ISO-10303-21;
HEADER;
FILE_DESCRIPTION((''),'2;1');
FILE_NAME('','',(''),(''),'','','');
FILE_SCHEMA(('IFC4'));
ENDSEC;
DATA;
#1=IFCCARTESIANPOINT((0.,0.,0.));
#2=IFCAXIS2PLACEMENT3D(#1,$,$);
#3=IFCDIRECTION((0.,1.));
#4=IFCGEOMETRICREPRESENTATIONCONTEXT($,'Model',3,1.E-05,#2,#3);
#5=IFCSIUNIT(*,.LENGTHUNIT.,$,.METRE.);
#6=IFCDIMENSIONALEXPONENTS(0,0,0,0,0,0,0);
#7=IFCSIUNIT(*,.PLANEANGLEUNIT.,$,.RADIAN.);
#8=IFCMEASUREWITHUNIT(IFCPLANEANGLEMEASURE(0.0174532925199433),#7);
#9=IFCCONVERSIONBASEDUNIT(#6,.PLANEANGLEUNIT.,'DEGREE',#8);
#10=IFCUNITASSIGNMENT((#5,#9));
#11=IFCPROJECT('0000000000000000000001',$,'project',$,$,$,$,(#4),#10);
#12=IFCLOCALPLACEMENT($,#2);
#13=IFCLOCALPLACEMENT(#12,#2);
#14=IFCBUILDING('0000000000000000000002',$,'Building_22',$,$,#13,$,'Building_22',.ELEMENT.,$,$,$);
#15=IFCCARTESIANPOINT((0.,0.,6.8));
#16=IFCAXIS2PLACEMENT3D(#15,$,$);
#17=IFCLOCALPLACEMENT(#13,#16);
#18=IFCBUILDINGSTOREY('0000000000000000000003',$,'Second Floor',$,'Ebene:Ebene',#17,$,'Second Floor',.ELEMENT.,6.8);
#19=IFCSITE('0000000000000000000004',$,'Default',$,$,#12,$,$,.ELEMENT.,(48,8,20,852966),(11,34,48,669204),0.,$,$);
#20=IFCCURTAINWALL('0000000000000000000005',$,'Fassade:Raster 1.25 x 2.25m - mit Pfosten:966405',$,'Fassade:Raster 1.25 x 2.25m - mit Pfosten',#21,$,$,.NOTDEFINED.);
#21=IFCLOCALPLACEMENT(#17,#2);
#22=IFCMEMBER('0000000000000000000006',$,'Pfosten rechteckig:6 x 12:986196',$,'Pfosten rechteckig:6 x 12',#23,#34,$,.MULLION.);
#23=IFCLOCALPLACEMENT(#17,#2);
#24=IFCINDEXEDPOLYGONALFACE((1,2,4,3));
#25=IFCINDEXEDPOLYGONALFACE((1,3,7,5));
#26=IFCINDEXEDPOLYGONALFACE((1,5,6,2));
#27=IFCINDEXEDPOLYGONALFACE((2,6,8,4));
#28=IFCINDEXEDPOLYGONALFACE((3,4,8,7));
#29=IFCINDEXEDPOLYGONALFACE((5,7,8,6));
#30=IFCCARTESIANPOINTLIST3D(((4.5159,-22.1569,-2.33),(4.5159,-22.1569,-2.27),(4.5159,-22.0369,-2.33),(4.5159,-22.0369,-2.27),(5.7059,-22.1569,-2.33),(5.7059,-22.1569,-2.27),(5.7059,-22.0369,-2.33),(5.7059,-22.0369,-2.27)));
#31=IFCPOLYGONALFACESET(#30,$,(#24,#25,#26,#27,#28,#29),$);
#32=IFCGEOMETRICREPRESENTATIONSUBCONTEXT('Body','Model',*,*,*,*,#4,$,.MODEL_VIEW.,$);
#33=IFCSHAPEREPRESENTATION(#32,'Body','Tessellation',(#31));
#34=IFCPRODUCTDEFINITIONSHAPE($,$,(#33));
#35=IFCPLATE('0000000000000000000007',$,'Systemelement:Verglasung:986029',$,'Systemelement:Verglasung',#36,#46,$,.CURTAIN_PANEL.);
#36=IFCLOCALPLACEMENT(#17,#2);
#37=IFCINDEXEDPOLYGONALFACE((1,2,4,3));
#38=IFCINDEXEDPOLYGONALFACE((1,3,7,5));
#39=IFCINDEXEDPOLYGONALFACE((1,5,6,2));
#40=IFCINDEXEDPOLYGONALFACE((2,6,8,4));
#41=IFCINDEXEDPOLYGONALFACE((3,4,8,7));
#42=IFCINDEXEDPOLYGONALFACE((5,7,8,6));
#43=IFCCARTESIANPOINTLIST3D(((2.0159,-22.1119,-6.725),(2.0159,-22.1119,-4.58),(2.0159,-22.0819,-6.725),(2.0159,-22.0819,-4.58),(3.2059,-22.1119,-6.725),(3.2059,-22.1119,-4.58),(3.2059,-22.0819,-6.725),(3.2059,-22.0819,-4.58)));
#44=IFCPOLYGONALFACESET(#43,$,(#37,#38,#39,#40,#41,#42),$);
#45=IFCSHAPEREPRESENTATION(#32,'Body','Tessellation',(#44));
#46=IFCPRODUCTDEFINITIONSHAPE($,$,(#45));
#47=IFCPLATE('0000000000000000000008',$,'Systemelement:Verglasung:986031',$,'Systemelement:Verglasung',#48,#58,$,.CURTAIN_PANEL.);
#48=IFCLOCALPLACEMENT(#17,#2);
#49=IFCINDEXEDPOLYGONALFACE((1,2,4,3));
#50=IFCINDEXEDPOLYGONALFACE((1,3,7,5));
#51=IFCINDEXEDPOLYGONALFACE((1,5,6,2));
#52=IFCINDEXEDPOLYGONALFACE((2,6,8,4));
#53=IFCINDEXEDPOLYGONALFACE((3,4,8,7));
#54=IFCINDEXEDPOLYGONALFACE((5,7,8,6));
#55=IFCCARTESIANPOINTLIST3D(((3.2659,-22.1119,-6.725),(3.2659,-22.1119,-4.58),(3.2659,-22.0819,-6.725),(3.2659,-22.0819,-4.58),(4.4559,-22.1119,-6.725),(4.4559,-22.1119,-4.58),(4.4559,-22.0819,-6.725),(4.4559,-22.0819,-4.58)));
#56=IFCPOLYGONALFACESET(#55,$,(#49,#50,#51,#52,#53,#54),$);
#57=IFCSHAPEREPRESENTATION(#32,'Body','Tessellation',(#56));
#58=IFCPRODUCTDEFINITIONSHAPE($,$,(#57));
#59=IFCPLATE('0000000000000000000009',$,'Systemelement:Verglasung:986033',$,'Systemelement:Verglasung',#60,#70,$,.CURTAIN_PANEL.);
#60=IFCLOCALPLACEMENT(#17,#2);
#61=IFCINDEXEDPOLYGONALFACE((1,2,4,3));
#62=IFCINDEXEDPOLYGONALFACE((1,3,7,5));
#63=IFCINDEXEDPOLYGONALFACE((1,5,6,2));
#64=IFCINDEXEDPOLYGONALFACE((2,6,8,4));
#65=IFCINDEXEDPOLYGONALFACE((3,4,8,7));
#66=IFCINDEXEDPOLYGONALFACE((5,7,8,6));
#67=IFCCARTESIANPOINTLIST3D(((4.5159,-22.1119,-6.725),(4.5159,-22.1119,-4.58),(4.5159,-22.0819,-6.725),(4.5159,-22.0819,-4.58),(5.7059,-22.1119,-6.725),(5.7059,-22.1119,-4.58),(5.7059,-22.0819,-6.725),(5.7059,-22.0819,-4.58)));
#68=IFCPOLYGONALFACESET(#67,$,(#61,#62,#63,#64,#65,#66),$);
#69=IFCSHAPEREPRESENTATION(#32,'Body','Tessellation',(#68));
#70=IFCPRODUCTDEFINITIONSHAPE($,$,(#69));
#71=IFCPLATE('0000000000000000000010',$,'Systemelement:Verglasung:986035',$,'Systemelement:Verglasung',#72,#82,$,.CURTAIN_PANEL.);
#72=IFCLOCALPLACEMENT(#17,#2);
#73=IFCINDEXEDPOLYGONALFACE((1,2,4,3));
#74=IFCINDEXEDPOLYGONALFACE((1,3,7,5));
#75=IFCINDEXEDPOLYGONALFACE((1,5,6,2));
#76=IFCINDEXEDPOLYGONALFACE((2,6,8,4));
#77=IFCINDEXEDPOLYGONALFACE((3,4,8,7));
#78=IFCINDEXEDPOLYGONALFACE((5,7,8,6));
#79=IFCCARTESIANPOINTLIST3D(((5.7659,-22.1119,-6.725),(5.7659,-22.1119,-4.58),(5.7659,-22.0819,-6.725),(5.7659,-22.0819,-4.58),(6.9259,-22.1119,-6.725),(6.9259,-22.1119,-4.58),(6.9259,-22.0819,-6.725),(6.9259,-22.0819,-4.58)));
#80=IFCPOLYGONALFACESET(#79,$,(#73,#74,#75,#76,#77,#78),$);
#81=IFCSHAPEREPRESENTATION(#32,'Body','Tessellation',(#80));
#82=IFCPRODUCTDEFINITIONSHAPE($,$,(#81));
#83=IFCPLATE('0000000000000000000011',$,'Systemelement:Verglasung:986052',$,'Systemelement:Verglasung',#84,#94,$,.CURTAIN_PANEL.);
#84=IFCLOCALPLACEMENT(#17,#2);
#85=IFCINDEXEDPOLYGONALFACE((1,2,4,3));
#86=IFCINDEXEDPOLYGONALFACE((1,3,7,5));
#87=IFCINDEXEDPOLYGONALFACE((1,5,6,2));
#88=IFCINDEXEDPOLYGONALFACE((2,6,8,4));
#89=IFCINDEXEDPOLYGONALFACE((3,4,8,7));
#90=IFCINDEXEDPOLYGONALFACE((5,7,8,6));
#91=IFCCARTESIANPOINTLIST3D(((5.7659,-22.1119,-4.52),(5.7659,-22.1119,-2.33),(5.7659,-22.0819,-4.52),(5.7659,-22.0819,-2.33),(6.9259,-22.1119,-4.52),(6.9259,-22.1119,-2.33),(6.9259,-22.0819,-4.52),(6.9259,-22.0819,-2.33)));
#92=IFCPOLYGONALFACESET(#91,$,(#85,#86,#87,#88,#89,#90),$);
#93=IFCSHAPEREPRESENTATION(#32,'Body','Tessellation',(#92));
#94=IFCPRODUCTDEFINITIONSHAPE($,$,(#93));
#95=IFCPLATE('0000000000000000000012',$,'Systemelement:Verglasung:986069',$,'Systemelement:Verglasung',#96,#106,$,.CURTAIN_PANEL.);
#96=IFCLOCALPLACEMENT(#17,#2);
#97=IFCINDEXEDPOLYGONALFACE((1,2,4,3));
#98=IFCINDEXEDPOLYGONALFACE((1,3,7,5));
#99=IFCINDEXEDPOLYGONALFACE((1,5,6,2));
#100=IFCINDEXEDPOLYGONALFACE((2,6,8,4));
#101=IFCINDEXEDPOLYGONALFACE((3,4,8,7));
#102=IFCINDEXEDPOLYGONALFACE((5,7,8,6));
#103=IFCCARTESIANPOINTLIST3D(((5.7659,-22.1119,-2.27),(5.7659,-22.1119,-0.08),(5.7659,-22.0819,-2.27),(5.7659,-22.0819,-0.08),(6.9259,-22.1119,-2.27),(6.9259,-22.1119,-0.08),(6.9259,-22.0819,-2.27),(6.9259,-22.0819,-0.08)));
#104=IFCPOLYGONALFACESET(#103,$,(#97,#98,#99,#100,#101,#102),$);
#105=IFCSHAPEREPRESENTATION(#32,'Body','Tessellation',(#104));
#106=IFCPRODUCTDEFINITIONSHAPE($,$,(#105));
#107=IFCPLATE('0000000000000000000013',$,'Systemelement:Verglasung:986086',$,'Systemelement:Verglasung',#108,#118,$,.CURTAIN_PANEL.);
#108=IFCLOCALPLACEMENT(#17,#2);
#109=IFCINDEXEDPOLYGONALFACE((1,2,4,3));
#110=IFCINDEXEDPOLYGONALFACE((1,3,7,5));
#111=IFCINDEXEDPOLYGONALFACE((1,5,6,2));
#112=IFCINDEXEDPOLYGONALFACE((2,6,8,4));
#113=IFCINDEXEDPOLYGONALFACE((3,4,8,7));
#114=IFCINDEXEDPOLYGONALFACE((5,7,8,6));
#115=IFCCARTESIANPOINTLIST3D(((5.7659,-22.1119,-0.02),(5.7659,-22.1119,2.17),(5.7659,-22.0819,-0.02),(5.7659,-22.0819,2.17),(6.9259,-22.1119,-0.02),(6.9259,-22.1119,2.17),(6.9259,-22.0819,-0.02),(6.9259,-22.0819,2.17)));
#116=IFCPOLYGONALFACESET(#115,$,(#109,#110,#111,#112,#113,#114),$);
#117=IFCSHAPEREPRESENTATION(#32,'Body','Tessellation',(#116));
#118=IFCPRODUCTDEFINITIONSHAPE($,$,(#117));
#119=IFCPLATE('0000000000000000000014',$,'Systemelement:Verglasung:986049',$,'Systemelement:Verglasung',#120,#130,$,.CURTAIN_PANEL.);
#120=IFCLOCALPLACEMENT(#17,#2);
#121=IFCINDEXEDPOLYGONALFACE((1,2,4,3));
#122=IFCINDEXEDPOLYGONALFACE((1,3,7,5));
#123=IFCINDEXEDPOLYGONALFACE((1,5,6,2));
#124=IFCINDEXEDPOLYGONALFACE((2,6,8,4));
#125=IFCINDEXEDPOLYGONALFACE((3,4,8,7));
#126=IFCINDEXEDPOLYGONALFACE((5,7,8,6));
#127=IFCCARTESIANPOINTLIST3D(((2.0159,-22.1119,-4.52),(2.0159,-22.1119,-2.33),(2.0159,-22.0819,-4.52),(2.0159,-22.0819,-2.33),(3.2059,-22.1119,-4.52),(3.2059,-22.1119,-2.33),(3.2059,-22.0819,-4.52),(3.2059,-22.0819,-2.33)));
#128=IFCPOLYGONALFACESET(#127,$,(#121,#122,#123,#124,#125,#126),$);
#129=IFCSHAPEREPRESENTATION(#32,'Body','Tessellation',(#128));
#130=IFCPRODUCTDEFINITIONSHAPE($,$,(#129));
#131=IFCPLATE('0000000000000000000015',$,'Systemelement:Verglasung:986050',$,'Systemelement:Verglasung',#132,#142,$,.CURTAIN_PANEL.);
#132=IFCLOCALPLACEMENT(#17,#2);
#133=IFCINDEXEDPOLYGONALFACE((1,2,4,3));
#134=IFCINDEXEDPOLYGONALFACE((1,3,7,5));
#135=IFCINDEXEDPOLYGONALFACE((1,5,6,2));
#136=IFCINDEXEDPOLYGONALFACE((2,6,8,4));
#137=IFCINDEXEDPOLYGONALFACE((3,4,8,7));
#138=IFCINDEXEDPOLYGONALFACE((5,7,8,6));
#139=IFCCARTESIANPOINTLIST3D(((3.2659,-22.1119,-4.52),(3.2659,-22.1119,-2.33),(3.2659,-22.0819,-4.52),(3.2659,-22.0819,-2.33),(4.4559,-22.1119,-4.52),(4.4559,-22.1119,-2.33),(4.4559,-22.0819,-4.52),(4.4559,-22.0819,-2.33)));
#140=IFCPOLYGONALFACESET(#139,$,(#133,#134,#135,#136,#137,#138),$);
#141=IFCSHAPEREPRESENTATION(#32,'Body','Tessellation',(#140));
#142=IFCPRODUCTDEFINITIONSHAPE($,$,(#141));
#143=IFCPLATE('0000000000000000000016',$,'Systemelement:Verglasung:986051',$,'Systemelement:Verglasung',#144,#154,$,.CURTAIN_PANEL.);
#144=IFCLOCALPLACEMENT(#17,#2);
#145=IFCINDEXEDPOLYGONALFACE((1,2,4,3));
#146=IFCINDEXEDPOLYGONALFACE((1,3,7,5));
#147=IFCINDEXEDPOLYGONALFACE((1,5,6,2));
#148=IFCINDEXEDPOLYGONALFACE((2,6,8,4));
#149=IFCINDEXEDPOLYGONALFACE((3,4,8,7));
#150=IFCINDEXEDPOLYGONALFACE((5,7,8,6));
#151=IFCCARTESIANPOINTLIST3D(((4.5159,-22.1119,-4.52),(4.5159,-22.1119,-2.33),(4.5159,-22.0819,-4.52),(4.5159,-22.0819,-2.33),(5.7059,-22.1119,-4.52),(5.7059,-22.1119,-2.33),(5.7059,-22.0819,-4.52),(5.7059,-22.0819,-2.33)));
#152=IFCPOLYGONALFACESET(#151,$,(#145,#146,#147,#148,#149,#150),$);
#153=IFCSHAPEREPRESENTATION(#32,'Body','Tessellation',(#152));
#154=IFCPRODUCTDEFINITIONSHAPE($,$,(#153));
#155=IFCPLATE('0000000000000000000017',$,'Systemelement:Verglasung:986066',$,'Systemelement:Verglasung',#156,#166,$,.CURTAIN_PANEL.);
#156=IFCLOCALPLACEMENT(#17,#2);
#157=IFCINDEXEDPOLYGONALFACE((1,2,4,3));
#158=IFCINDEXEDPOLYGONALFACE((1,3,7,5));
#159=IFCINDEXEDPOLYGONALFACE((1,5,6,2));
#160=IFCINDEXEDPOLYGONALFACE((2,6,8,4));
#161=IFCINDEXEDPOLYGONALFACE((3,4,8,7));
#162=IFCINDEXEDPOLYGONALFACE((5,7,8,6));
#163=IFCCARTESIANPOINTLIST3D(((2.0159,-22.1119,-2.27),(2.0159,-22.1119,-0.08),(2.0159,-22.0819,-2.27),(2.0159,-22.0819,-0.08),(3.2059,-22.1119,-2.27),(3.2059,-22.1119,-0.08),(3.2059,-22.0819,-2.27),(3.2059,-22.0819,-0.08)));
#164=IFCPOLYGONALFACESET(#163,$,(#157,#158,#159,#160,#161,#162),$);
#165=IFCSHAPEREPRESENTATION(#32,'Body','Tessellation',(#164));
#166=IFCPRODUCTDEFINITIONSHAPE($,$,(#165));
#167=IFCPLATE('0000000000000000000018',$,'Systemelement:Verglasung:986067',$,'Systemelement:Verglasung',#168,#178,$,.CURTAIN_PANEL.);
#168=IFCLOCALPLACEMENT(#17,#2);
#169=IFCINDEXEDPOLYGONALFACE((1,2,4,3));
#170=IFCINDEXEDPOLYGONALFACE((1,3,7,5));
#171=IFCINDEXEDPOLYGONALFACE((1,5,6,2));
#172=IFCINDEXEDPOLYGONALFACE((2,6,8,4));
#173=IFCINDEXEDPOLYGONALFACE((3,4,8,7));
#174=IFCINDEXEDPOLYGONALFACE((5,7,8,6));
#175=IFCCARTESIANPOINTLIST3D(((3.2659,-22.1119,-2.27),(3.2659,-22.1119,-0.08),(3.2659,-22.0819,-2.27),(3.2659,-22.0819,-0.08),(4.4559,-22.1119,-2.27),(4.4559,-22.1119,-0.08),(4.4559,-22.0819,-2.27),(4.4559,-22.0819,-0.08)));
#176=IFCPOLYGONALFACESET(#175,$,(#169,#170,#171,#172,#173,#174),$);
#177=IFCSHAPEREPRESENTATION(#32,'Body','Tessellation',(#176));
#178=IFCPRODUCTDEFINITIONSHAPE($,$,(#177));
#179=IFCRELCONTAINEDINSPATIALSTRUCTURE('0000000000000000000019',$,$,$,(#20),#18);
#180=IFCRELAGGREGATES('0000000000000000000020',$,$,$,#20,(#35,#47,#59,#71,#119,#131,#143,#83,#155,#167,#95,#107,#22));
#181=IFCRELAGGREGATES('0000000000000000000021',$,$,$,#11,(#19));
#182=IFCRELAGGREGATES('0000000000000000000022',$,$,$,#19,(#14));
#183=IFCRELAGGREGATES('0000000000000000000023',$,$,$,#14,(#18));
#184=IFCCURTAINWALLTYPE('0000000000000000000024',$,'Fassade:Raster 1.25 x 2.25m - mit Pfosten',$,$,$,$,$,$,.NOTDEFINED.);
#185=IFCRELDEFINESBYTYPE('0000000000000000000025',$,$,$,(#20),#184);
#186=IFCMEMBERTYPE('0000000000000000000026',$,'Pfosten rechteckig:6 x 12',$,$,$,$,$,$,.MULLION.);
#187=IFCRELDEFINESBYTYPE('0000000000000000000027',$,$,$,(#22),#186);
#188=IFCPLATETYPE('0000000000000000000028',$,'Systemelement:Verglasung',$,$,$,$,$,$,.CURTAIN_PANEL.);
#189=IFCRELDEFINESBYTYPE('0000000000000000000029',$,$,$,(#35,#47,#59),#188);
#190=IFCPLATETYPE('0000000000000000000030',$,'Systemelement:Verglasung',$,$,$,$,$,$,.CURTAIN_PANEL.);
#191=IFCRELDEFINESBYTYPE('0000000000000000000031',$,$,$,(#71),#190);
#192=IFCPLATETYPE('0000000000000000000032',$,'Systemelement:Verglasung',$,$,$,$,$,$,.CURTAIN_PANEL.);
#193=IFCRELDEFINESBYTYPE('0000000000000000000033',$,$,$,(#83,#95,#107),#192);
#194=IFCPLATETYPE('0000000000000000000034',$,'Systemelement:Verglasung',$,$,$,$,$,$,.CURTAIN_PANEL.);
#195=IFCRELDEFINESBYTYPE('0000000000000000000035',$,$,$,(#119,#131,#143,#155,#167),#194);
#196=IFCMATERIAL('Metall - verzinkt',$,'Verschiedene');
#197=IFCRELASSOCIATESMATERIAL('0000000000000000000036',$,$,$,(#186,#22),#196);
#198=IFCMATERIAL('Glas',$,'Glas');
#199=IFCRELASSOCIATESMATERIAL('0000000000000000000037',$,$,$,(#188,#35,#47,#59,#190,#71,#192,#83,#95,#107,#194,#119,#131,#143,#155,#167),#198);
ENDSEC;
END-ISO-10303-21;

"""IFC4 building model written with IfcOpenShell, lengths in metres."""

from ifc_helpers import new_model, entity, si_unit, converted_unit, direction, frame, origin, place, context, subcontext, project, spatial, indexed_curve, outline, extrude, source, transform, mapped, material, type_object, type_shapes, element, aggregate, save


model = new_model("IFC4")

# Units and contexts
model_context = context("Model", 3, precision=1e-05, world=origin(), true_north=direction((0.0, 1.0)))
body_context = subcontext(model_context, "Body", "Model", "MODEL_VIEW")
ifc_project = project(units=[si_unit("LENGTHUNIT", "METRE"), converted_unit("PLANEANGLEUNIT", "DEGREE", entity("IfcPlaneAngleMeasure", 0.0174532925199433), si_unit("PLANEANGLEUNIT", "RADIAN"), dimensions=[0, 0, 0, 0, 0, 0, 0])], contexts=[model_context])

# Site, building, storey
site_placement = place(None, origin())
site = spatial("IfcSite", under=ifc_project, at=site_placement, Name="Default", CompositionType="ELEMENT", RefLatitude=(48, 8, 20, 852966), RefLongitude=(11, 34, 48, 669204), RefElevation=0.0)
building_placement = place(site_placement, origin())
building = spatial("IfcBuilding", under=site, at=building_placement, Name="Building_22", LongName="Building_22", CompositionType="ELEMENT")
storey_placement = place(building_placement, frame((0.0, 0.0, 6.8)))
storey = spatial("IfcBuildingStorey", under=building, at=storey_placement, Name="Second Floor", ObjectType="Ebene:Ebene", LongName="Second Floor", CompositionType="ELEMENT", Elevation=6.8)

# Curtain wall, member, plates
curtain_wall_type = type_object("IfcCurtainWallType", Name="Fassade:Raster 1.25 x 2.25m - mit Pfosten", PredefinedType="NOTDEFINED")
curtain_wall_placement = place(storey_placement, frame((0.0, 0.0, -6.8)))
curtain_wall = element("IfcCurtainWall", 1, at=curtain_wall_placement, inside=storey, type_object=curtain_wall_type, Name="Fassade:Raster 1.25 x 2.25m - mit Pfosten:966405", ObjectType="Fassade:Raster 1.25 x 2.25m - mit Pfosten", PredefinedType="NOTDEFINED")
ifc_material_1 = material(Name="Metall - verzinkt", Category="Verschiedene")
member_type_1 = type_object("IfcMemberType", Name="Pfosten rechteckig:6 x 12", PredefinedType="MULLION", material=ifc_material_1)
shared_shape_1 = source(origin(), body_context, "Body", "SweptSolid", [
    extrude(outline(indexed_curve([(-0.03, -0.06), (0.03, -0.06), (0.03, 0.06), (-0.03, 0.06), (-0.03, -0.06)], self_intersect=False)), frame((0.0, 0.0, -1.19), z_axis=(0.0, 0.0, 1.0), x_axis=(-1.0, 0.0, 0.0)), (0.0, 0.0, 1.0), 1.19),
])
type_shapes(member_type_1, [shared_shape_1])
member_1_placement = place(curtain_wall_placement, frame((5.7059, -22.0969, 4.5), z_axis=(1.0, 0.0, 0.0), x_axis=(0.0, 0.0, 1.0)))
member_1 = element("IfcMember", 2, at=member_1_placement, type_object=member_type_1, material=ifc_material_1, Name="Pfosten rechteckig:6 x 12:986196", ObjectType="Pfosten rechteckig:6 x 12", PredefinedType="MULLION", context=body_context, shape_type="MappedRepresentation", body=[
    mapped(shared_shape_1, transform((0.0, 0.0, 0.0), scale=1.0)),
])
ifc_material_2 = material(Name="Glas", Category="Glas")
plate_type_1 = type_object("IfcPlateType", Name="Systemelement:Verglasung", PredefinedType="CURTAIN_PANEL", material=ifc_material_2)
shared_shape_2 = source(origin(), body_context, "Body", "SweptSolid", [
    extrude(outline(indexed_curve([(-0.015, -0.595), (0.015, -0.595), (0.015, 0.595), (-0.015, 0.595), (-0.015, -0.595)], self_intersect=False)), frame((0.0, 0.0, 0.0), z_axis=(0.0, 0.0, 1.0), x_axis=(0.0, 1.0, 0.0)), (0.0, 0.0, 1.0), 2.145),
])
type_shapes(plate_type_1, [shared_shape_2])
plate_1_placement = place(curtain_wall_placement, frame((2.6109, -22.0969, 0.075)))
plate_1 = element("IfcPlate", 3, at=plate_1_placement, type_object=plate_type_1, material=ifc_material_2, Name="Systemelement:Verglasung:986029", ObjectType="Systemelement:Verglasung", PredefinedType="CURTAIN_PANEL", context=body_context, shape_type="MappedRepresentation", body=[
    mapped(shared_shape_2, transform((0.0, 0.0, 0.0), scale=1.0)),
])
plate_2_placement = place(curtain_wall_placement, frame((3.8609, -22.0969, 0.075)))
plate_2 = element("IfcPlate", 4, at=plate_2_placement, type_object=plate_type_1, material=ifc_material_2, Name="Systemelement:Verglasung:986031", ObjectType="Systemelement:Verglasung", PredefinedType="CURTAIN_PANEL", context=body_context, shape_type="MappedRepresentation", body=[
    mapped(shared_shape_2, transform((0.0, 0.0, 0.0), scale=1.0)),
])
plate_3_placement = place(curtain_wall_placement, frame((5.1109, -22.0969, 0.075)))
plate_3 = element("IfcPlate", 5, at=plate_3_placement, type_object=plate_type_1, material=ifc_material_2, Name="Systemelement:Verglasung:986033", ObjectType="Systemelement:Verglasung", PredefinedType="CURTAIN_PANEL", context=body_context, shape_type="MappedRepresentation", body=[
    mapped(shared_shape_2, transform((0.0, 0.0, 0.0), scale=1.0)),
])
plate_type_2 = type_object("IfcPlateType", Name="Systemelement:Verglasung", PredefinedType="CURTAIN_PANEL", material=ifc_material_2)
shared_shape_3 = source(origin(), body_context, "Body", "SweptSolid", [
    extrude(outline(indexed_curve([(-0.015, -0.58), (0.015, -0.58), (0.015, 0.58), (-0.015, 0.58), (-0.015, -0.58)], self_intersect=False)), frame((0.0, 0.0, 0.0), z_axis=(0.0, 0.0, 1.0), x_axis=(0.0, 1.0, 0.0)), (0.0, 0.0, 1.0), 2.145),
])
type_shapes(plate_type_2, [shared_shape_3])
plate_4_placement = place(curtain_wall_placement, frame((6.3459, -22.0969, 0.075)))
plate_4 = element("IfcPlate", 6, at=plate_4_placement, type_object=plate_type_2, material=ifc_material_2, Name="Systemelement:Verglasung:986035", ObjectType="Systemelement:Verglasung", PredefinedType="CURTAIN_PANEL", context=body_context, shape_type="MappedRepresentation", body=[
    mapped(shared_shape_3, transform((0.0, 0.0, 0.0), scale=1.0)),
])
plate_type_3 = type_object("IfcPlateType", Name="Systemelement:Verglasung", PredefinedType="CURTAIN_PANEL", material=ifc_material_2)
shared_shape_4 = source(origin(), body_context, "Body", "SweptSolid", [
    extrude(outline(indexed_curve([(-0.015, -0.58), (0.015, -0.58), (0.015, 0.58), (-0.015, 0.58), (-0.015, -0.58)], self_intersect=False)), frame((0.0, 0.0, 0.0), z_axis=(0.0, 0.0, 1.0), x_axis=(0.0, 1.0, 0.0)), (0.0, 0.0, 1.0), 2.19),
])
type_shapes(plate_type_3, [shared_shape_4])
plate_5_placement = place(curtain_wall_placement, frame((6.3459, -22.0969, 2.28)))
plate_5 = element("IfcPlate", 7, at=plate_5_placement, type_object=plate_type_3, material=ifc_material_2, Name="Systemelement:Verglasung:986052", ObjectType="Systemelement:Verglasung", PredefinedType="CURTAIN_PANEL", context=body_context, shape_type="MappedRepresentation", body=[
    mapped(shared_shape_4, transform((0.0, 0.0, 0.0), scale=1.0)),
])
plate_6_placement = place(curtain_wall_placement, frame((6.3459, -22.0969, 4.53)))
plate_6 = element("IfcPlate", 8, at=plate_6_placement, type_object=plate_type_3, material=ifc_material_2, Name="Systemelement:Verglasung:986069", ObjectType="Systemelement:Verglasung", PredefinedType="CURTAIN_PANEL", context=body_context, shape_type="MappedRepresentation", body=[
    mapped(shared_shape_4, transform((0.0, 0.0, 0.0), scale=1.0)),
])
plate_7_placement = place(curtain_wall_placement, frame((6.3459, -22.0969, 6.78)))
plate_7 = element("IfcPlate", 9, at=plate_7_placement, type_object=plate_type_3, material=ifc_material_2, Name="Systemelement:Verglasung:986086", ObjectType="Systemelement:Verglasung", PredefinedType="CURTAIN_PANEL", context=body_context, shape_type="MappedRepresentation", body=[
    mapped(shared_shape_4, transform((0.0, 0.0, 0.0), scale=1.0)),
])
plate_type_4 = type_object("IfcPlateType", Name="Systemelement:Verglasung", PredefinedType="CURTAIN_PANEL", material=ifc_material_2)
shared_shape_5 = source(origin(), body_context, "Body", "SweptSolid", [
    extrude(outline(indexed_curve([(-0.015, -0.595), (0.015, -0.595), (0.015, 0.595), (-0.015, 0.595), (-0.015, -0.595)], self_intersect=False)), frame((0.0, 0.0, 0.0), z_axis=(0.0, 0.0, 1.0), x_axis=(0.0, 1.0, 0.0)), (0.0, 0.0, 1.0), 2.19),
])
type_shapes(plate_type_4, [shared_shape_5])
plate_8_placement = place(curtain_wall_placement, frame((2.6109, -22.0969, 2.28)))
plate_8 = element("IfcPlate", 10, at=plate_8_placement, type_object=plate_type_4, material=ifc_material_2, Name="Systemelement:Verglasung:986049", ObjectType="Systemelement:Verglasung", PredefinedType="CURTAIN_PANEL", context=body_context, shape_type="MappedRepresentation", body=[
    mapped(shared_shape_5, transform((0.0, 0.0, 0.0), scale=1.0)),
])
plate_9_placement = place(curtain_wall_placement, frame((3.8609, -22.0969, 2.28)))
plate_9 = element("IfcPlate", 11, at=plate_9_placement, type_object=plate_type_4, material=ifc_material_2, Name="Systemelement:Verglasung:986050", ObjectType="Systemelement:Verglasung", PredefinedType="CURTAIN_PANEL", context=body_context, shape_type="MappedRepresentation", body=[
    mapped(shared_shape_5, transform((0.0, 0.0, 0.0), scale=1.0)),
])
plate_10_placement = place(curtain_wall_placement, frame((5.1109, -22.0969, 2.28)))
plate_10 = element("IfcPlate", 12, at=plate_10_placement, type_object=plate_type_4, material=ifc_material_2, Name="Systemelement:Verglasung:986051", ObjectType="Systemelement:Verglasung", PredefinedType="CURTAIN_PANEL", context=body_context, shape_type="MappedRepresentation", body=[
    mapped(shared_shape_5, transform((0.0, 0.0, 0.0), scale=1.0)),
])
plate_11_placement = place(curtain_wall_placement, frame((2.6109, -22.0969, 4.53)))
plate_11 = element("IfcPlate", 13, at=plate_11_placement, type_object=plate_type_4, material=ifc_material_2, Name="Systemelement:Verglasung:986066", ObjectType="Systemelement:Verglasung", PredefinedType="CURTAIN_PANEL", context=body_context, shape_type="MappedRepresentation", body=[
    mapped(shared_shape_5, transform((0.0, 0.0, 0.0), scale=1.0)),
])
plate_12_placement = place(curtain_wall_placement, frame((3.8609, -22.0969, 4.53)))
plate_12 = element("IfcPlate", 14, at=plate_12_placement, type_object=plate_type_4, material=ifc_material_2, Name="Systemelement:Verglasung:986067", ObjectType="Systemelement:Verglasung", PredefinedType="CURTAIN_PANEL", context=body_context, shape_type="MappedRepresentation", body=[
    mapped(shared_shape_5, transform((0.0, 0.0, 0.0), scale=1.0)),
])
aggregate(curtain_wall, [plate_1, plate_2, plate_3, plate_4, plate_8, plate_9, plate_10, plate_5, plate_11, plate_12, plate_6, plate_7, member_1])

save(model, "model.ifc")
